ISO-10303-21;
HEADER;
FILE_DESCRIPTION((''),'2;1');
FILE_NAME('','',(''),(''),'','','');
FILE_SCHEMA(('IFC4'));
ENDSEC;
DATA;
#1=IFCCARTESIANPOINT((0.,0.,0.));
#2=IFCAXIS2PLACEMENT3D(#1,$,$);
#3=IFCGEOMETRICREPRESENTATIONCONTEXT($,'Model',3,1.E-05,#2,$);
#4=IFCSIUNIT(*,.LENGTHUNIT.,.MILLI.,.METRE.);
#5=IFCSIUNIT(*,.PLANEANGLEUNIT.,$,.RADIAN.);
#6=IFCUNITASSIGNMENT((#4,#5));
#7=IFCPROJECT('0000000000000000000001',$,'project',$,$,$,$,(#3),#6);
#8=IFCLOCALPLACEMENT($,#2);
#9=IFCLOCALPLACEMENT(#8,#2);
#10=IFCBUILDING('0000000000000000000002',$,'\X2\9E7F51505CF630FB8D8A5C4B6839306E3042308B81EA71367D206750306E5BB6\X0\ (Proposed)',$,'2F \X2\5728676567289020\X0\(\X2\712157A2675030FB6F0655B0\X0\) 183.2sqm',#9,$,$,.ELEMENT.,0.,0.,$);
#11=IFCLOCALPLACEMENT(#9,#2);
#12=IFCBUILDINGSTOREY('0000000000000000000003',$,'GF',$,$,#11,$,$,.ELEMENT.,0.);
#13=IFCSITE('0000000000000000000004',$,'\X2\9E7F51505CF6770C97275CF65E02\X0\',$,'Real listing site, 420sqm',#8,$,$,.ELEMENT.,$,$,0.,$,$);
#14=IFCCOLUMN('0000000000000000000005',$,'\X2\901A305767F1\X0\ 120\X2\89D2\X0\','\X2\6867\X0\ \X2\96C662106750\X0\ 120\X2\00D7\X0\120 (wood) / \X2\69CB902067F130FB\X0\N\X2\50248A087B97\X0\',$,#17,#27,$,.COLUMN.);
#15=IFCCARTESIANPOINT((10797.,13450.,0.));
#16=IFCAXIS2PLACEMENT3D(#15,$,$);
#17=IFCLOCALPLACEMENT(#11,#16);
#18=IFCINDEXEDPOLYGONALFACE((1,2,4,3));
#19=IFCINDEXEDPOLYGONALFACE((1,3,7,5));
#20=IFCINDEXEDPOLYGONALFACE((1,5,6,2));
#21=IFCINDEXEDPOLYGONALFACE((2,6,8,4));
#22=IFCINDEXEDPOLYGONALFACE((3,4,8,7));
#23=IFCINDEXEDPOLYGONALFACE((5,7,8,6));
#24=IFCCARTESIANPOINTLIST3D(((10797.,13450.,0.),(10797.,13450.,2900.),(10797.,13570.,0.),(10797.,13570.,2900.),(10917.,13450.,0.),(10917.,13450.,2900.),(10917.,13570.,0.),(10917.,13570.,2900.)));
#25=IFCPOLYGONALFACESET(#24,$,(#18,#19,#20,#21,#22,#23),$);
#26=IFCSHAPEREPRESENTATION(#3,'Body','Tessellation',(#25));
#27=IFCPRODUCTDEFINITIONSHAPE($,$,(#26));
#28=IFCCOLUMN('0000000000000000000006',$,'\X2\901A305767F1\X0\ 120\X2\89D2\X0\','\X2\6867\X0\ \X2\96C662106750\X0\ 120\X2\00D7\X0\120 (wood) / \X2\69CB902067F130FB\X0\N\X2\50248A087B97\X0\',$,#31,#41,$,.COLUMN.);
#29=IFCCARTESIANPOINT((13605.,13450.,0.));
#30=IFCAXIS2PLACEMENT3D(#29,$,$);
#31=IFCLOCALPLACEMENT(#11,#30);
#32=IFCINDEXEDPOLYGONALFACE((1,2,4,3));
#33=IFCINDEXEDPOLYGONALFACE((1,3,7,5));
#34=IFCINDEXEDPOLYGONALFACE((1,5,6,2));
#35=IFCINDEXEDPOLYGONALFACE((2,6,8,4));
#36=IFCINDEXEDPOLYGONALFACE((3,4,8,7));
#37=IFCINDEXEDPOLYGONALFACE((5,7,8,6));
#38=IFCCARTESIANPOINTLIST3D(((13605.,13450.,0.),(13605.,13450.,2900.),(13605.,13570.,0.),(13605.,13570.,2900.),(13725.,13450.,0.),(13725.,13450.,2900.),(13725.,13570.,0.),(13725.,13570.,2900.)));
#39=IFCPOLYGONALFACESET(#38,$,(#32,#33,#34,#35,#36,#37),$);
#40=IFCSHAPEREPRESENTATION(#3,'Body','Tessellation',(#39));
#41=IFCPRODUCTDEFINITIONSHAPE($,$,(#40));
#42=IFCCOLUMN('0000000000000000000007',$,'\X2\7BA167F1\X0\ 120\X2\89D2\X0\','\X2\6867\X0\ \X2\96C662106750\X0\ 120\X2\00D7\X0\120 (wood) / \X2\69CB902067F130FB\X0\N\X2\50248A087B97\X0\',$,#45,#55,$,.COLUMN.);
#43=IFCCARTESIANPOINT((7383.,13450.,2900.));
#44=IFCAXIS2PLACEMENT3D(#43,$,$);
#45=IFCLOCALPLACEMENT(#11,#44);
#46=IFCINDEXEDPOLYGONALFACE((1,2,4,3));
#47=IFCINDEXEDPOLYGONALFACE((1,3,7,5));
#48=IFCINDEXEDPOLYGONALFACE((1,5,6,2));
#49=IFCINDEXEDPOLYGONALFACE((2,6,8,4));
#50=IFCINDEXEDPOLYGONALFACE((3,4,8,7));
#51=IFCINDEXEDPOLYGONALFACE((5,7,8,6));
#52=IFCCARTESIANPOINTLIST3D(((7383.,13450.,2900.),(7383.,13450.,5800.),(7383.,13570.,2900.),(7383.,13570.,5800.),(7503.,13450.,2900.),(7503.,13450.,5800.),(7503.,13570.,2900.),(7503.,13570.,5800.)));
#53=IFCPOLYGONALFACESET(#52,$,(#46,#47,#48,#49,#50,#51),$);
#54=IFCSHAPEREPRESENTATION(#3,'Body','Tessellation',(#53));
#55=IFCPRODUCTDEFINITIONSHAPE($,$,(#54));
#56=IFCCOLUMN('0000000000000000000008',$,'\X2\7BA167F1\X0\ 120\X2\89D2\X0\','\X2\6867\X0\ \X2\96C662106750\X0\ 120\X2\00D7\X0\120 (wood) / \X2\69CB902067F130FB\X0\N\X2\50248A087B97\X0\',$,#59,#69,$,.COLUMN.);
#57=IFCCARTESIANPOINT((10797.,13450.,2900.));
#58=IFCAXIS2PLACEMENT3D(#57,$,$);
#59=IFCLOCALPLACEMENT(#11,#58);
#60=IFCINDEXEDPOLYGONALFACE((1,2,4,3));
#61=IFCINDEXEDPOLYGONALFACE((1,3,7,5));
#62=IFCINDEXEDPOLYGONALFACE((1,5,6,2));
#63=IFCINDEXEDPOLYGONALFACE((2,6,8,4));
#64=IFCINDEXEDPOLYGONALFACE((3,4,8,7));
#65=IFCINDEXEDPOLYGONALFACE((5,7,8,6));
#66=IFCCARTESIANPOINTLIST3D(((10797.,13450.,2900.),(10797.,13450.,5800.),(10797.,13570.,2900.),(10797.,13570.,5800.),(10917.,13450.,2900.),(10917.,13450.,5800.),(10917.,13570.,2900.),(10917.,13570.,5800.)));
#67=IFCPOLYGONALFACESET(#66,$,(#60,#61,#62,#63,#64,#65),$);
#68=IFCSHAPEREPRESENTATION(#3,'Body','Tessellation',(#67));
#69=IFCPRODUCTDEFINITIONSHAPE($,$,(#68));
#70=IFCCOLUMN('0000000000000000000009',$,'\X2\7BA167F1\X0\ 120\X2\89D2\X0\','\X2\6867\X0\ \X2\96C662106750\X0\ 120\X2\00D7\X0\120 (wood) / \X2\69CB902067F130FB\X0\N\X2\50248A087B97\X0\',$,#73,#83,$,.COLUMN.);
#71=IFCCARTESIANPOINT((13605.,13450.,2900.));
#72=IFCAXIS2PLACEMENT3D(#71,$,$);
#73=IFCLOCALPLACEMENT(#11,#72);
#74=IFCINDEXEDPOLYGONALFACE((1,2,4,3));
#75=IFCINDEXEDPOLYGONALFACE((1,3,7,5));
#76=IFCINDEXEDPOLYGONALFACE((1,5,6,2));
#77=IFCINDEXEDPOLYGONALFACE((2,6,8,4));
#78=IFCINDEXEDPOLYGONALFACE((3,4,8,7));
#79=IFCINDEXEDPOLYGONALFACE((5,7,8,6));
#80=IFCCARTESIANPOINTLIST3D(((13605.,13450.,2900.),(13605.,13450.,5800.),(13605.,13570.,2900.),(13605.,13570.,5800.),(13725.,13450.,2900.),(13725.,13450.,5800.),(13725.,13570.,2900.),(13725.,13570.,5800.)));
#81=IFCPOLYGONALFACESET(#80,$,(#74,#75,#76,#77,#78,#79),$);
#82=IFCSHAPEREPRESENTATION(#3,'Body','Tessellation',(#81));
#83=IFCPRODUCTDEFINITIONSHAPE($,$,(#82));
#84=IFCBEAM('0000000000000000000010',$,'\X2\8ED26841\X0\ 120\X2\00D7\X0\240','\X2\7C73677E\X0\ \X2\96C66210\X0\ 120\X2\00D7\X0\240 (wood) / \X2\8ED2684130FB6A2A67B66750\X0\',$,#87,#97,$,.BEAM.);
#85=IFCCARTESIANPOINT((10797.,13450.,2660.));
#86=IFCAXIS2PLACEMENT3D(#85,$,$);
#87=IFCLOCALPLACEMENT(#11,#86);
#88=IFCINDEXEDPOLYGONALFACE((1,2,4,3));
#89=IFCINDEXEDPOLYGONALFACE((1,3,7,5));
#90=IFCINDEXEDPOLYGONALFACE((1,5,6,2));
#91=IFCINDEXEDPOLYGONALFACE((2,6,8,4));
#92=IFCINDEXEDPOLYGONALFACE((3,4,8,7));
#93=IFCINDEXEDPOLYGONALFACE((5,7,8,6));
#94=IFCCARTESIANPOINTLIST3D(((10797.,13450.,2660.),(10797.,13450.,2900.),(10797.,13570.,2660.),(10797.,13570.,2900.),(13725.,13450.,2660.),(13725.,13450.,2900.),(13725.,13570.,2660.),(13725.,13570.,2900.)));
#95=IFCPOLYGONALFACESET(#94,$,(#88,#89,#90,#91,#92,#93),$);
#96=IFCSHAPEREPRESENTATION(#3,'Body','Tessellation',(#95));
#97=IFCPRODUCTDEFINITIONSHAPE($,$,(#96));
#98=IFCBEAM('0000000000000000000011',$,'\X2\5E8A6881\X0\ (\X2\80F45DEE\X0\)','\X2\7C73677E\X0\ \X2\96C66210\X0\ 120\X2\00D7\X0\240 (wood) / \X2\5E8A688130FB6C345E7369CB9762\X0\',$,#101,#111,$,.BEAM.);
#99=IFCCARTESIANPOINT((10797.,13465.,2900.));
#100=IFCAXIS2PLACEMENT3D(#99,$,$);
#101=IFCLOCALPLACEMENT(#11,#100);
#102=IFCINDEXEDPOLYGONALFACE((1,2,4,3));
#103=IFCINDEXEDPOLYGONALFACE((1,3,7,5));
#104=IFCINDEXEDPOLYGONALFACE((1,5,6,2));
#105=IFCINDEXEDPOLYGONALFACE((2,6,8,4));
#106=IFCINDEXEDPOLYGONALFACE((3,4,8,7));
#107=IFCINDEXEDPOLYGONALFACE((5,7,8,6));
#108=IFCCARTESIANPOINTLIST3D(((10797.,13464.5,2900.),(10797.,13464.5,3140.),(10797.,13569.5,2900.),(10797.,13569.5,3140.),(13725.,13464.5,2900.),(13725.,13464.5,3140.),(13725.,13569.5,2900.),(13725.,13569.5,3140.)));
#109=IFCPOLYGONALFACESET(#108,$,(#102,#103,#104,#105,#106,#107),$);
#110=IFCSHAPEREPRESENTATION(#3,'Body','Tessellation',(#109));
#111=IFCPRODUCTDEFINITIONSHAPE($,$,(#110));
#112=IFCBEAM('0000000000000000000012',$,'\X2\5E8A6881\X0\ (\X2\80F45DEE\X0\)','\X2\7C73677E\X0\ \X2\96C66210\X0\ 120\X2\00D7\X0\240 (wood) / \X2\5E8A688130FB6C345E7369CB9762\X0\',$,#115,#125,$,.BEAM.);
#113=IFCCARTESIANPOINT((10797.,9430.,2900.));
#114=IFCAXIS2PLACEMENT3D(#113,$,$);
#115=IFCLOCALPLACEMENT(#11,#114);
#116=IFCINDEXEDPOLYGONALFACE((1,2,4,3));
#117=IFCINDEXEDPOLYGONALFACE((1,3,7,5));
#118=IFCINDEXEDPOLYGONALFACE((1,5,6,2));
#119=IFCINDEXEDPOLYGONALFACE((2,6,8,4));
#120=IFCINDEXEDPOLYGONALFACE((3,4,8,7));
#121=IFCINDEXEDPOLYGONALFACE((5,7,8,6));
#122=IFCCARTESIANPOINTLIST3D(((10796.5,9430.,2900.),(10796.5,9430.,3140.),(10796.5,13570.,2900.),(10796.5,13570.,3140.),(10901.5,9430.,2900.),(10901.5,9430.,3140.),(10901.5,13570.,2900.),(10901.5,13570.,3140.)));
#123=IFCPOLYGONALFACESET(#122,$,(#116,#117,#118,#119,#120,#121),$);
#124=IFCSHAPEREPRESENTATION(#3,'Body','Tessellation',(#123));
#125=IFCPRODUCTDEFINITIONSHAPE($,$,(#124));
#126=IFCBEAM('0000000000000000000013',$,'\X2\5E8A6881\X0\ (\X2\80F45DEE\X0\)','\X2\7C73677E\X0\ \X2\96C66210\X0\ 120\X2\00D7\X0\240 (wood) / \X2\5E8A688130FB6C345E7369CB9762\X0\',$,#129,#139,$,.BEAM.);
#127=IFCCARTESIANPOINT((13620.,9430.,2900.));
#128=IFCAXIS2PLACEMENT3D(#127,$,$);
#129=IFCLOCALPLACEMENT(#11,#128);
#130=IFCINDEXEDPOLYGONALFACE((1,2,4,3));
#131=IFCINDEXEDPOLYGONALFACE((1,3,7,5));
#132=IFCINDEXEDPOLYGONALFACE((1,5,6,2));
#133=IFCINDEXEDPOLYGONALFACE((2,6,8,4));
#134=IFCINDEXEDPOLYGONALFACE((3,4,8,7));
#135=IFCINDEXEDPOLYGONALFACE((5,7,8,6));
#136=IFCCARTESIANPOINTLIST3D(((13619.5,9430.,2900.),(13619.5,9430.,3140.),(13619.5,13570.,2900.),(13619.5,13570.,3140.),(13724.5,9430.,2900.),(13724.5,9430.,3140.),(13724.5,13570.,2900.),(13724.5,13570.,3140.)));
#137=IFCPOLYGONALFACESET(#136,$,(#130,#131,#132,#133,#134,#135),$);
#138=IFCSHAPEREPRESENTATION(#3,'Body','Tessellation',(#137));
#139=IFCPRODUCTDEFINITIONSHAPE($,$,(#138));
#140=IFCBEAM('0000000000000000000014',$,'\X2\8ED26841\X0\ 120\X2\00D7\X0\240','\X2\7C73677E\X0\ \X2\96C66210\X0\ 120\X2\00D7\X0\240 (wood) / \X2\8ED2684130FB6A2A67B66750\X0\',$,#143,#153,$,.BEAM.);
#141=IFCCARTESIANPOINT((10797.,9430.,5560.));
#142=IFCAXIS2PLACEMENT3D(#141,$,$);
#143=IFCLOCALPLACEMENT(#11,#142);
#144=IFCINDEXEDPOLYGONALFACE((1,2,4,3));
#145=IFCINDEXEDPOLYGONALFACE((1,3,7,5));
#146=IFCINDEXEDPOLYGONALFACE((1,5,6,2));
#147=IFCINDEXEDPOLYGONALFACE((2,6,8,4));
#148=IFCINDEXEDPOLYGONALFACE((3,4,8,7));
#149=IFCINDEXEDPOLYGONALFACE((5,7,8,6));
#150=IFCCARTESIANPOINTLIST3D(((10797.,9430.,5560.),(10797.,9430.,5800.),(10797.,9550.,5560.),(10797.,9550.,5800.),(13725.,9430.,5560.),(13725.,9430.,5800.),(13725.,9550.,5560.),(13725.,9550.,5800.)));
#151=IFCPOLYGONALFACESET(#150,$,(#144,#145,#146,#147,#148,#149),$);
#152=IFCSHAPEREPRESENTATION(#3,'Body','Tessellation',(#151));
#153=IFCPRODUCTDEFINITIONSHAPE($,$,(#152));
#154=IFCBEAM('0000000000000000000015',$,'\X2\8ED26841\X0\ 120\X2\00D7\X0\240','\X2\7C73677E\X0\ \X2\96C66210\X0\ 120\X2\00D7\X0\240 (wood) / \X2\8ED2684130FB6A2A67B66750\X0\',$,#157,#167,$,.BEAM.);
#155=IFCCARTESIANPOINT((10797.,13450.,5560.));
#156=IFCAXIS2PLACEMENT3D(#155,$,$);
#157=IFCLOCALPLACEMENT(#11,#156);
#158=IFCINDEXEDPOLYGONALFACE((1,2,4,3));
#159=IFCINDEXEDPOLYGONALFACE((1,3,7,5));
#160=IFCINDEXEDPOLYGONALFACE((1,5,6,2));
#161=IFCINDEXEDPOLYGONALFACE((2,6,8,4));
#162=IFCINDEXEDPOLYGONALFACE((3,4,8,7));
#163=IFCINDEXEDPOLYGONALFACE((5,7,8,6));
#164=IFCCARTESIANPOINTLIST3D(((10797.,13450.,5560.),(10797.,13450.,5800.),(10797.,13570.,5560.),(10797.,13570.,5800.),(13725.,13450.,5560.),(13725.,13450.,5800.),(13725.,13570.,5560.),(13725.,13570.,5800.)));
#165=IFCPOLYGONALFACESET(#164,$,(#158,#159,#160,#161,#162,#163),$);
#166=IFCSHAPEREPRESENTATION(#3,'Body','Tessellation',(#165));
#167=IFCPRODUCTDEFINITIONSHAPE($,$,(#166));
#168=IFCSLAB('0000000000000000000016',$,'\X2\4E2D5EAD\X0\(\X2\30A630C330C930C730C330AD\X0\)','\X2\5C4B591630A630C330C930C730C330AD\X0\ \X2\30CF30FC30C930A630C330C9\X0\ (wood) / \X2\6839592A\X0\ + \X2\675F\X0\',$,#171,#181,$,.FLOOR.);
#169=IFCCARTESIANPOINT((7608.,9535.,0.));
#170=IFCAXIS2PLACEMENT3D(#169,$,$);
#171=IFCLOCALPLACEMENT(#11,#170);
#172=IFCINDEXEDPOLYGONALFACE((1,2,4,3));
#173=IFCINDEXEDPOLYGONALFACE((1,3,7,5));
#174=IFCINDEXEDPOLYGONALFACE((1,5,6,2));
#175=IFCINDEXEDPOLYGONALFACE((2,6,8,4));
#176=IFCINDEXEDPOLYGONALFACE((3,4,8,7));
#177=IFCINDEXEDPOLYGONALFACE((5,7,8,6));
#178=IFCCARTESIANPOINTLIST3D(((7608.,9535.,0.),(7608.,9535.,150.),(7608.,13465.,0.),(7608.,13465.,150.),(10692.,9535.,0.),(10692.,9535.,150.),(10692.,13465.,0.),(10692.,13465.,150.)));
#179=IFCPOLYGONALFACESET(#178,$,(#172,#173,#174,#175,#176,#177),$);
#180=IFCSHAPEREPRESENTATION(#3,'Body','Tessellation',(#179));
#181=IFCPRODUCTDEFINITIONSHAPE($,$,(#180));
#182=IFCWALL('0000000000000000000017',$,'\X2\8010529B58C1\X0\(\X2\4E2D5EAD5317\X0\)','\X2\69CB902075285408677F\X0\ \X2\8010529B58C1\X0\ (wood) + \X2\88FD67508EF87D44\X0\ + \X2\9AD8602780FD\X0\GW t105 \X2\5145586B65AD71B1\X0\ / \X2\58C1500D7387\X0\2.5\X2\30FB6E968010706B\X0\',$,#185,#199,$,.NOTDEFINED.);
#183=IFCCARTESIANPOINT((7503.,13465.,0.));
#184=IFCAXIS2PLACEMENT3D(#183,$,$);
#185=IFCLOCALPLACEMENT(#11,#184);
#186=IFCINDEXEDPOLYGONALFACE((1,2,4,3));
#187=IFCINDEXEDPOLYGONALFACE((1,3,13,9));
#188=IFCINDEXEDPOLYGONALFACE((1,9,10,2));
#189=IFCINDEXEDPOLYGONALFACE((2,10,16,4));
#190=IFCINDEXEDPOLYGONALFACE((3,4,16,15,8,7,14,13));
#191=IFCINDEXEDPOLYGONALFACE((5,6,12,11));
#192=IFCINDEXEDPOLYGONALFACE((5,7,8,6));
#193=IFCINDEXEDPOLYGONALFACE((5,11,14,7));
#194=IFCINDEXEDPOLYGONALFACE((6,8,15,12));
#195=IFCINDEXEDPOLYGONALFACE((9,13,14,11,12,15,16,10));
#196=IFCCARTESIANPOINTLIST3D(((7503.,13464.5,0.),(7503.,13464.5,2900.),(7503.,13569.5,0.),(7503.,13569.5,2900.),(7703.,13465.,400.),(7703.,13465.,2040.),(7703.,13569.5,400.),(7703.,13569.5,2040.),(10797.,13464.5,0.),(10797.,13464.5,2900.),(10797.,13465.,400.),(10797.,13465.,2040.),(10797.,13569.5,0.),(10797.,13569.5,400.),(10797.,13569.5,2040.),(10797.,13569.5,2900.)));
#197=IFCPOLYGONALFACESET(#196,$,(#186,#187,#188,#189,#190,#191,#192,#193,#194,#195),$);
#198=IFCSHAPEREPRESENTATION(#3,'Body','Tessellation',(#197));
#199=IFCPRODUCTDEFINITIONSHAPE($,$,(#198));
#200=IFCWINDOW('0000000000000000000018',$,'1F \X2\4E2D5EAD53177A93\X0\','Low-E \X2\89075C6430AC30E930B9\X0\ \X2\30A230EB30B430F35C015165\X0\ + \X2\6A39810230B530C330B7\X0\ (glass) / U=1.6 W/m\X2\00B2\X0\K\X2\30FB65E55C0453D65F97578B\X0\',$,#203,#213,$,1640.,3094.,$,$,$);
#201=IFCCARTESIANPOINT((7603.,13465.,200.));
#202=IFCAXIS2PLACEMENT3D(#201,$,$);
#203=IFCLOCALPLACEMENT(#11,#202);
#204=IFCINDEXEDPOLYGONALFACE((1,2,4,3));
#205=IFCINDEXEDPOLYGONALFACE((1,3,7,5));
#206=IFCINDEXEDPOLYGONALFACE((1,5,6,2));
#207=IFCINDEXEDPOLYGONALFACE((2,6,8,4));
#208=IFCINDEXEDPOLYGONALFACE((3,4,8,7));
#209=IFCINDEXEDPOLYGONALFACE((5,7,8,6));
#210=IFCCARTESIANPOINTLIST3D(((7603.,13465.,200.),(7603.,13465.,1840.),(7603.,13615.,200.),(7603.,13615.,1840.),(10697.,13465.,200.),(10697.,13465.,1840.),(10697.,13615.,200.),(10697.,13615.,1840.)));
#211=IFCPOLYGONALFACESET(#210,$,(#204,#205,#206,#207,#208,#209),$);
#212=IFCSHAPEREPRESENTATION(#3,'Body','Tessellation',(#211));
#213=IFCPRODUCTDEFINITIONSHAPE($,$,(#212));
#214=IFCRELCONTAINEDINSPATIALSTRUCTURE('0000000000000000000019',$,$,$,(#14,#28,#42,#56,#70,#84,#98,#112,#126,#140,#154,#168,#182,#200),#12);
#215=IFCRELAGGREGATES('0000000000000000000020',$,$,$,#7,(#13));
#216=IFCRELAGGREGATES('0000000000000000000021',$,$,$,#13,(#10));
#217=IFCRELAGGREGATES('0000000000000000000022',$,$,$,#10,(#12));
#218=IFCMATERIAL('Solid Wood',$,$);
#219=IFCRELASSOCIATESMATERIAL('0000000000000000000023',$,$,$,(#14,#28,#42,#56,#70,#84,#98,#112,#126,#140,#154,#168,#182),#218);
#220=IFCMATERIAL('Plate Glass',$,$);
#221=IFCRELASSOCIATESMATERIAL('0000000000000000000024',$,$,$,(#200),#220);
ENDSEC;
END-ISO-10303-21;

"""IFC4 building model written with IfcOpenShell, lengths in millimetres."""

from ifc_helpers import new_model, si_unit, frame, frame_2d, origin, place, context, project, spatial, rectangle, extrude, material, element, fill, save


model = new_model("IFC4")

# Units and contexts
model_context = context("Model", 3, precision=1e-05, world=origin())
ifc_project = project(units=[si_unit("LENGTHUNIT", "METRE", prefix="MILLI"), si_unit("PLANEANGLEUNIT", "RADIAN")], contexts=[model_context])

# Site, building, storey
site_placement = place(None, origin())
site = spatial("IfcSite", under=ifc_project, at=site_placement, Name="鹿児島県霧島市", ObjectType="Real listing site, 420sqm", CompositionType="ELEMENT", RefElevation=0.0)
building_placement = place(site_placement, origin())
building = spatial("IfcBuilding", under=site, at=building_placement, Name="鹿児島・越屋根のある自然素材の家 (Proposed)", ObjectType="2F 在来木造(無垢材・漆喰) 183.2sqm", CompositionType="ELEMENT", ElevationOfRefHeight=0.0, ElevationOfTerrain=0.0)
storey_placement = place(building_placement, origin())
storey = spatial("IfcBuildingStorey", under=building, at=storey_placement, Name="GF", CompositionType="ELEMENT", Elevation=0.0)

# Columns
ifc_material_1 = material(Name="Solid Wood")
column_1_placement = place(storey_placement, frame((10797.0, 13450.0, 0.0)))
element("IfcColumn", 1, at=column_1_placement, inside=storey, material=ifc_material_1, Name="通し柱 120角", Description="桧 集成材 120×120 (wood) / 構造柱・N値計算", PredefinedType="COLUMN", context=model_context, shape_type="SweptSolid", body=[
    extrude(rectangle(XDim=120.0, YDim=120.0, at=frame_2d((60.0, 60.0))), frame((10797.0, 13450.0, 0.0)), (0.0, 0.0, 1.0), 2900.0),
])
column_2_placement = place(storey_placement, frame((13605.0, 13450.0, 0.0)))
element("IfcColumn", 2, at=column_2_placement, inside=storey, material=ifc_material_1, Name="通し柱 120角", Description="桧 集成材 120×120 (wood) / 構造柱・N値計算", PredefinedType="COLUMN", context=model_context, shape_type="SweptSolid", body=[
    extrude(rectangle(XDim=120.0, YDim=120.0, at=frame_2d((60.0, 60.0))), frame((13605.0, 13450.0, 0.0)), (0.0, 0.0, 1.0), 2900.0),
])
column_3_placement = place(storey_placement, frame((7383.0, 13450.0, 2900.0)))
element("IfcColumn", 3, at=column_3_placement, inside=storey, material=ifc_material_1, Name="管柱 120角", Description="桧 集成材 120×120 (wood) / 構造柱・N値計算", PredefinedType="COLUMN", context=model_context, shape_type="SweptSolid", body=[
    extrude(rectangle(XDim=120.0, YDim=120.0, at=frame_2d((60.0, 60.0))), frame((7383.0, 13450.0, 2900.0)), (0.0, 0.0, 1.0), 2900.0),
])
column_4_placement = place(storey_placement, frame((10797.0, 13450.0, 2900.0)))
element("IfcColumn", 4, at=column_4_placement, inside=storey, material=ifc_material_1, Name="管柱 120角", Description="桧 集成材 120×120 (wood) / 構造柱・N値計算", PredefinedType="COLUMN", context=model_context, shape_type="SweptSolid", body=[
    extrude(rectangle(XDim=120.0, YDim=120.0, at=frame_2d((60.0, 60.0))), frame((10797.0, 13450.0, 2900.0)), (0.0, 0.0, 1.0), 2900.0),
])
column_5_placement = place(storey_placement, frame((13605.0, 13450.0, 2900.0)))
element("IfcColumn", 5, at=column_5_placement, inside=storey, material=ifc_material_1, Name="管柱 120角", Description="桧 集成材 120×120 (wood) / 構造柱・N値計算", PredefinedType="COLUMN", context=model_context, shape_type="SweptSolid", body=[
    extrude(rectangle(XDim=120.0, YDim=120.0, at=frame_2d((60.0, 60.0))), frame((13605.0, 13450.0, 2900.0)), (0.0, 0.0, 1.0), 2900.0),
])

# Beams
beam_1_placement = place(storey_placement, frame((10797.0, 13450.0, 2660.0)))
element("IfcBeam", 6, at=beam_1_placement, inside=storey, material=ifc_material_1, Name="軒桁 120×240", Description="米松 集成 120×240 (wood) / 軒桁・横架材", PredefinedType="BEAM", context=model_context, shape_type="SweptSolid", body=[
    extrude(rectangle(XDim=2928.0, YDim=120.0, at=frame_2d((1464.0, 60.0))), frame((10797.0, 13450.0, 2660.0)), (0.0, 0.0, 1.0), 240.0),
])
beam_2_placement = place(storey_placement, frame((10797.0, 13465.0, 2900.0)))
element("IfcBeam", 7, at=beam_2_placement, inside=storey, material=ifc_material_1, Name="床梁 (胴差)", Description="米松 集成 120×240 (wood) / 床梁・水平構面", PredefinedType="BEAM", context=model_context, shape_type="SweptSolid", body=[
    extrude(rectangle(XDim=2928.0, YDim=105.0, at=frame_2d((1464.0, 52.0))), frame((10797.0, 13465.0, 2900.0)), (0.0, 0.0, 1.0), 240.0),
])
beam_3_placement = place(storey_placement, frame((10797.0, 9430.0, 2900.0)))
element("IfcBeam", 8, at=beam_3_placement, inside=storey, material=ifc_material_1, Name="床梁 (胴差)", Description="米松 集成 120×240 (wood) / 床梁・水平構面", PredefinedType="BEAM", context=model_context, shape_type="SweptSolid", body=[
    extrude(rectangle(XDim=105.0, YDim=4140.0, at=frame_2d((52.0, 2070.0))), frame((10797.0, 9430.0, 2900.0)), (0.0, 0.0, 1.0), 240.0),
])
beam_4_placement = place(storey_placement, frame((13620.0, 9430.0, 2900.0)))
element("IfcBeam", 9, at=beam_4_placement, inside=storey, material=ifc_material_1, Name="床梁 (胴差)", Description="米松 集成 120×240 (wood) / 床梁・水平構面", PredefinedType="BEAM", context=model_context, shape_type="SweptSolid", body=[
    extrude(rectangle(XDim=105.0, YDim=4140.0, at=frame_2d((52.0, 2070.0))), frame((13620.0, 9430.0, 2900.0)), (0.0, 0.0, 1.0), 240.0),
])
beam_5_placement = place(storey_placement, frame((10797.0, 9430.0, 5560.0)))
element("IfcBeam", 10, at=beam_5_placement, inside=storey, material=ifc_material_1, Name="軒桁 120×240", Description="米松 集成 120×240 (wood) / 軒桁・横架材", PredefinedType="BEAM", context=model_context, shape_type="SweptSolid", body=[
    extrude(rectangle(XDim=2928.0, YDim=120.0, at=frame_2d((1464.0, 60.0))), frame((10797.0, 9430.0, 5560.0)), (0.0, 0.0, 1.0), 240.0),
])
beam_6_placement = place(storey_placement, frame((10797.0, 13450.0, 5560.0)))
element("IfcBeam", 11, at=beam_6_placement, inside=storey, material=ifc_material_1, Name="軒桁 120×240", Description="米松 集成 120×240 (wood) / 軒桁・横架材", PredefinedType="BEAM", context=model_context, shape_type="SweptSolid", body=[
    extrude(rectangle(XDim=2928.0, YDim=120.0, at=frame_2d((1464.0, 60.0))), frame((10797.0, 13450.0, 5560.0)), (0.0, 0.0, 1.0), 240.0),
])

# Slab
slab_placement = place(storey_placement, frame((7608.0, 9535.0, 0.0)))
element("IfcSlab", 12, at=slab_placement, inside=storey, material=ifc_material_1, Name="中庭(ウッドデッキ)", Description="屋外ウッドデッキ ハードウッド (wood) / 根太 + 束", PredefinedType="FLOOR", context=model_context, shape_type="SweptSolid", body=[
    extrude(rectangle(XDim=3084.0, YDim=3930.0, at=frame_2d((1542.0, 1965.0))), frame((7608.0, 9535.0, 0.0)), (0.0, 0.0, 1.0), 150.0),
])

# Wall, opening, window
wall_1_placement = place(storey_placement, frame((7503.0, 13465.0, 0.0)))
wall_1 = element("IfcWall", 13, at=wall_1_placement, inside=storey, material=ifc_material_1, Name="耐力壁(中庭北)", Description="構造用合板 耐力壁 (wood) + 製材軸組 + 高性能GW t105 充填断熱 / 壁倍率2.5・準耐火", PredefinedType="NOTDEFINED", context=model_context, shape_type="SweptSolid", body=[
    extrude(rectangle(XDim=3294.0, YDim=105.0, at=frame_2d((1647.0, 52.0))), frame((7503.0, 13465.0, 0.0)), (0.0, 0.0, 1.0), 2900.0),
])
opening_1_placement = place(storey_placement, frame((7603.0, 13465.0, 200.0)))
opening_1 = element("IfcOpeningElement", 14, at=opening_1_placement, cuts=wall_1, PredefinedType="NOTDEFINED", context=model_context, shape_type="SweptSolid", body=[
    extrude(rectangle(XDim=3094.0, YDim=150.0, at=frame_2d((1547.0, 75.0))), frame((7603.0, 13465.0, 200.0)), (0.0, 0.0, 1.0), 1640.0),
])
ifc_material_2 = material(Name="Plate Glass")
window_1_placement = place(storey_placement, frame((7603.0, 13465.0, 200.0)))
window_1 = element("IfcWindow", 15, at=window_1_placement, inside=storey, material=ifc_material_2, Name="1F 中庭北窓", Description="Low-E 複層ガラス アルゴン封入 + 樹脂サッシ (glass) / U=1.6 W/m²K・日射取得型", OverallHeight=1640.0, OverallWidth=3094.0, context=model_context, shape_type="SweptSolid", body=[
    extrude(rectangle(XDim=3094.0, YDim=150.0, at=frame_2d((1547.0, 75.0))), frame((7603.0, 13465.0, 200.0)), (0.0, 0.0, 1.0), 1640.0),
])
fill(opening_1, window_1)

save(model, "model.ifc")
